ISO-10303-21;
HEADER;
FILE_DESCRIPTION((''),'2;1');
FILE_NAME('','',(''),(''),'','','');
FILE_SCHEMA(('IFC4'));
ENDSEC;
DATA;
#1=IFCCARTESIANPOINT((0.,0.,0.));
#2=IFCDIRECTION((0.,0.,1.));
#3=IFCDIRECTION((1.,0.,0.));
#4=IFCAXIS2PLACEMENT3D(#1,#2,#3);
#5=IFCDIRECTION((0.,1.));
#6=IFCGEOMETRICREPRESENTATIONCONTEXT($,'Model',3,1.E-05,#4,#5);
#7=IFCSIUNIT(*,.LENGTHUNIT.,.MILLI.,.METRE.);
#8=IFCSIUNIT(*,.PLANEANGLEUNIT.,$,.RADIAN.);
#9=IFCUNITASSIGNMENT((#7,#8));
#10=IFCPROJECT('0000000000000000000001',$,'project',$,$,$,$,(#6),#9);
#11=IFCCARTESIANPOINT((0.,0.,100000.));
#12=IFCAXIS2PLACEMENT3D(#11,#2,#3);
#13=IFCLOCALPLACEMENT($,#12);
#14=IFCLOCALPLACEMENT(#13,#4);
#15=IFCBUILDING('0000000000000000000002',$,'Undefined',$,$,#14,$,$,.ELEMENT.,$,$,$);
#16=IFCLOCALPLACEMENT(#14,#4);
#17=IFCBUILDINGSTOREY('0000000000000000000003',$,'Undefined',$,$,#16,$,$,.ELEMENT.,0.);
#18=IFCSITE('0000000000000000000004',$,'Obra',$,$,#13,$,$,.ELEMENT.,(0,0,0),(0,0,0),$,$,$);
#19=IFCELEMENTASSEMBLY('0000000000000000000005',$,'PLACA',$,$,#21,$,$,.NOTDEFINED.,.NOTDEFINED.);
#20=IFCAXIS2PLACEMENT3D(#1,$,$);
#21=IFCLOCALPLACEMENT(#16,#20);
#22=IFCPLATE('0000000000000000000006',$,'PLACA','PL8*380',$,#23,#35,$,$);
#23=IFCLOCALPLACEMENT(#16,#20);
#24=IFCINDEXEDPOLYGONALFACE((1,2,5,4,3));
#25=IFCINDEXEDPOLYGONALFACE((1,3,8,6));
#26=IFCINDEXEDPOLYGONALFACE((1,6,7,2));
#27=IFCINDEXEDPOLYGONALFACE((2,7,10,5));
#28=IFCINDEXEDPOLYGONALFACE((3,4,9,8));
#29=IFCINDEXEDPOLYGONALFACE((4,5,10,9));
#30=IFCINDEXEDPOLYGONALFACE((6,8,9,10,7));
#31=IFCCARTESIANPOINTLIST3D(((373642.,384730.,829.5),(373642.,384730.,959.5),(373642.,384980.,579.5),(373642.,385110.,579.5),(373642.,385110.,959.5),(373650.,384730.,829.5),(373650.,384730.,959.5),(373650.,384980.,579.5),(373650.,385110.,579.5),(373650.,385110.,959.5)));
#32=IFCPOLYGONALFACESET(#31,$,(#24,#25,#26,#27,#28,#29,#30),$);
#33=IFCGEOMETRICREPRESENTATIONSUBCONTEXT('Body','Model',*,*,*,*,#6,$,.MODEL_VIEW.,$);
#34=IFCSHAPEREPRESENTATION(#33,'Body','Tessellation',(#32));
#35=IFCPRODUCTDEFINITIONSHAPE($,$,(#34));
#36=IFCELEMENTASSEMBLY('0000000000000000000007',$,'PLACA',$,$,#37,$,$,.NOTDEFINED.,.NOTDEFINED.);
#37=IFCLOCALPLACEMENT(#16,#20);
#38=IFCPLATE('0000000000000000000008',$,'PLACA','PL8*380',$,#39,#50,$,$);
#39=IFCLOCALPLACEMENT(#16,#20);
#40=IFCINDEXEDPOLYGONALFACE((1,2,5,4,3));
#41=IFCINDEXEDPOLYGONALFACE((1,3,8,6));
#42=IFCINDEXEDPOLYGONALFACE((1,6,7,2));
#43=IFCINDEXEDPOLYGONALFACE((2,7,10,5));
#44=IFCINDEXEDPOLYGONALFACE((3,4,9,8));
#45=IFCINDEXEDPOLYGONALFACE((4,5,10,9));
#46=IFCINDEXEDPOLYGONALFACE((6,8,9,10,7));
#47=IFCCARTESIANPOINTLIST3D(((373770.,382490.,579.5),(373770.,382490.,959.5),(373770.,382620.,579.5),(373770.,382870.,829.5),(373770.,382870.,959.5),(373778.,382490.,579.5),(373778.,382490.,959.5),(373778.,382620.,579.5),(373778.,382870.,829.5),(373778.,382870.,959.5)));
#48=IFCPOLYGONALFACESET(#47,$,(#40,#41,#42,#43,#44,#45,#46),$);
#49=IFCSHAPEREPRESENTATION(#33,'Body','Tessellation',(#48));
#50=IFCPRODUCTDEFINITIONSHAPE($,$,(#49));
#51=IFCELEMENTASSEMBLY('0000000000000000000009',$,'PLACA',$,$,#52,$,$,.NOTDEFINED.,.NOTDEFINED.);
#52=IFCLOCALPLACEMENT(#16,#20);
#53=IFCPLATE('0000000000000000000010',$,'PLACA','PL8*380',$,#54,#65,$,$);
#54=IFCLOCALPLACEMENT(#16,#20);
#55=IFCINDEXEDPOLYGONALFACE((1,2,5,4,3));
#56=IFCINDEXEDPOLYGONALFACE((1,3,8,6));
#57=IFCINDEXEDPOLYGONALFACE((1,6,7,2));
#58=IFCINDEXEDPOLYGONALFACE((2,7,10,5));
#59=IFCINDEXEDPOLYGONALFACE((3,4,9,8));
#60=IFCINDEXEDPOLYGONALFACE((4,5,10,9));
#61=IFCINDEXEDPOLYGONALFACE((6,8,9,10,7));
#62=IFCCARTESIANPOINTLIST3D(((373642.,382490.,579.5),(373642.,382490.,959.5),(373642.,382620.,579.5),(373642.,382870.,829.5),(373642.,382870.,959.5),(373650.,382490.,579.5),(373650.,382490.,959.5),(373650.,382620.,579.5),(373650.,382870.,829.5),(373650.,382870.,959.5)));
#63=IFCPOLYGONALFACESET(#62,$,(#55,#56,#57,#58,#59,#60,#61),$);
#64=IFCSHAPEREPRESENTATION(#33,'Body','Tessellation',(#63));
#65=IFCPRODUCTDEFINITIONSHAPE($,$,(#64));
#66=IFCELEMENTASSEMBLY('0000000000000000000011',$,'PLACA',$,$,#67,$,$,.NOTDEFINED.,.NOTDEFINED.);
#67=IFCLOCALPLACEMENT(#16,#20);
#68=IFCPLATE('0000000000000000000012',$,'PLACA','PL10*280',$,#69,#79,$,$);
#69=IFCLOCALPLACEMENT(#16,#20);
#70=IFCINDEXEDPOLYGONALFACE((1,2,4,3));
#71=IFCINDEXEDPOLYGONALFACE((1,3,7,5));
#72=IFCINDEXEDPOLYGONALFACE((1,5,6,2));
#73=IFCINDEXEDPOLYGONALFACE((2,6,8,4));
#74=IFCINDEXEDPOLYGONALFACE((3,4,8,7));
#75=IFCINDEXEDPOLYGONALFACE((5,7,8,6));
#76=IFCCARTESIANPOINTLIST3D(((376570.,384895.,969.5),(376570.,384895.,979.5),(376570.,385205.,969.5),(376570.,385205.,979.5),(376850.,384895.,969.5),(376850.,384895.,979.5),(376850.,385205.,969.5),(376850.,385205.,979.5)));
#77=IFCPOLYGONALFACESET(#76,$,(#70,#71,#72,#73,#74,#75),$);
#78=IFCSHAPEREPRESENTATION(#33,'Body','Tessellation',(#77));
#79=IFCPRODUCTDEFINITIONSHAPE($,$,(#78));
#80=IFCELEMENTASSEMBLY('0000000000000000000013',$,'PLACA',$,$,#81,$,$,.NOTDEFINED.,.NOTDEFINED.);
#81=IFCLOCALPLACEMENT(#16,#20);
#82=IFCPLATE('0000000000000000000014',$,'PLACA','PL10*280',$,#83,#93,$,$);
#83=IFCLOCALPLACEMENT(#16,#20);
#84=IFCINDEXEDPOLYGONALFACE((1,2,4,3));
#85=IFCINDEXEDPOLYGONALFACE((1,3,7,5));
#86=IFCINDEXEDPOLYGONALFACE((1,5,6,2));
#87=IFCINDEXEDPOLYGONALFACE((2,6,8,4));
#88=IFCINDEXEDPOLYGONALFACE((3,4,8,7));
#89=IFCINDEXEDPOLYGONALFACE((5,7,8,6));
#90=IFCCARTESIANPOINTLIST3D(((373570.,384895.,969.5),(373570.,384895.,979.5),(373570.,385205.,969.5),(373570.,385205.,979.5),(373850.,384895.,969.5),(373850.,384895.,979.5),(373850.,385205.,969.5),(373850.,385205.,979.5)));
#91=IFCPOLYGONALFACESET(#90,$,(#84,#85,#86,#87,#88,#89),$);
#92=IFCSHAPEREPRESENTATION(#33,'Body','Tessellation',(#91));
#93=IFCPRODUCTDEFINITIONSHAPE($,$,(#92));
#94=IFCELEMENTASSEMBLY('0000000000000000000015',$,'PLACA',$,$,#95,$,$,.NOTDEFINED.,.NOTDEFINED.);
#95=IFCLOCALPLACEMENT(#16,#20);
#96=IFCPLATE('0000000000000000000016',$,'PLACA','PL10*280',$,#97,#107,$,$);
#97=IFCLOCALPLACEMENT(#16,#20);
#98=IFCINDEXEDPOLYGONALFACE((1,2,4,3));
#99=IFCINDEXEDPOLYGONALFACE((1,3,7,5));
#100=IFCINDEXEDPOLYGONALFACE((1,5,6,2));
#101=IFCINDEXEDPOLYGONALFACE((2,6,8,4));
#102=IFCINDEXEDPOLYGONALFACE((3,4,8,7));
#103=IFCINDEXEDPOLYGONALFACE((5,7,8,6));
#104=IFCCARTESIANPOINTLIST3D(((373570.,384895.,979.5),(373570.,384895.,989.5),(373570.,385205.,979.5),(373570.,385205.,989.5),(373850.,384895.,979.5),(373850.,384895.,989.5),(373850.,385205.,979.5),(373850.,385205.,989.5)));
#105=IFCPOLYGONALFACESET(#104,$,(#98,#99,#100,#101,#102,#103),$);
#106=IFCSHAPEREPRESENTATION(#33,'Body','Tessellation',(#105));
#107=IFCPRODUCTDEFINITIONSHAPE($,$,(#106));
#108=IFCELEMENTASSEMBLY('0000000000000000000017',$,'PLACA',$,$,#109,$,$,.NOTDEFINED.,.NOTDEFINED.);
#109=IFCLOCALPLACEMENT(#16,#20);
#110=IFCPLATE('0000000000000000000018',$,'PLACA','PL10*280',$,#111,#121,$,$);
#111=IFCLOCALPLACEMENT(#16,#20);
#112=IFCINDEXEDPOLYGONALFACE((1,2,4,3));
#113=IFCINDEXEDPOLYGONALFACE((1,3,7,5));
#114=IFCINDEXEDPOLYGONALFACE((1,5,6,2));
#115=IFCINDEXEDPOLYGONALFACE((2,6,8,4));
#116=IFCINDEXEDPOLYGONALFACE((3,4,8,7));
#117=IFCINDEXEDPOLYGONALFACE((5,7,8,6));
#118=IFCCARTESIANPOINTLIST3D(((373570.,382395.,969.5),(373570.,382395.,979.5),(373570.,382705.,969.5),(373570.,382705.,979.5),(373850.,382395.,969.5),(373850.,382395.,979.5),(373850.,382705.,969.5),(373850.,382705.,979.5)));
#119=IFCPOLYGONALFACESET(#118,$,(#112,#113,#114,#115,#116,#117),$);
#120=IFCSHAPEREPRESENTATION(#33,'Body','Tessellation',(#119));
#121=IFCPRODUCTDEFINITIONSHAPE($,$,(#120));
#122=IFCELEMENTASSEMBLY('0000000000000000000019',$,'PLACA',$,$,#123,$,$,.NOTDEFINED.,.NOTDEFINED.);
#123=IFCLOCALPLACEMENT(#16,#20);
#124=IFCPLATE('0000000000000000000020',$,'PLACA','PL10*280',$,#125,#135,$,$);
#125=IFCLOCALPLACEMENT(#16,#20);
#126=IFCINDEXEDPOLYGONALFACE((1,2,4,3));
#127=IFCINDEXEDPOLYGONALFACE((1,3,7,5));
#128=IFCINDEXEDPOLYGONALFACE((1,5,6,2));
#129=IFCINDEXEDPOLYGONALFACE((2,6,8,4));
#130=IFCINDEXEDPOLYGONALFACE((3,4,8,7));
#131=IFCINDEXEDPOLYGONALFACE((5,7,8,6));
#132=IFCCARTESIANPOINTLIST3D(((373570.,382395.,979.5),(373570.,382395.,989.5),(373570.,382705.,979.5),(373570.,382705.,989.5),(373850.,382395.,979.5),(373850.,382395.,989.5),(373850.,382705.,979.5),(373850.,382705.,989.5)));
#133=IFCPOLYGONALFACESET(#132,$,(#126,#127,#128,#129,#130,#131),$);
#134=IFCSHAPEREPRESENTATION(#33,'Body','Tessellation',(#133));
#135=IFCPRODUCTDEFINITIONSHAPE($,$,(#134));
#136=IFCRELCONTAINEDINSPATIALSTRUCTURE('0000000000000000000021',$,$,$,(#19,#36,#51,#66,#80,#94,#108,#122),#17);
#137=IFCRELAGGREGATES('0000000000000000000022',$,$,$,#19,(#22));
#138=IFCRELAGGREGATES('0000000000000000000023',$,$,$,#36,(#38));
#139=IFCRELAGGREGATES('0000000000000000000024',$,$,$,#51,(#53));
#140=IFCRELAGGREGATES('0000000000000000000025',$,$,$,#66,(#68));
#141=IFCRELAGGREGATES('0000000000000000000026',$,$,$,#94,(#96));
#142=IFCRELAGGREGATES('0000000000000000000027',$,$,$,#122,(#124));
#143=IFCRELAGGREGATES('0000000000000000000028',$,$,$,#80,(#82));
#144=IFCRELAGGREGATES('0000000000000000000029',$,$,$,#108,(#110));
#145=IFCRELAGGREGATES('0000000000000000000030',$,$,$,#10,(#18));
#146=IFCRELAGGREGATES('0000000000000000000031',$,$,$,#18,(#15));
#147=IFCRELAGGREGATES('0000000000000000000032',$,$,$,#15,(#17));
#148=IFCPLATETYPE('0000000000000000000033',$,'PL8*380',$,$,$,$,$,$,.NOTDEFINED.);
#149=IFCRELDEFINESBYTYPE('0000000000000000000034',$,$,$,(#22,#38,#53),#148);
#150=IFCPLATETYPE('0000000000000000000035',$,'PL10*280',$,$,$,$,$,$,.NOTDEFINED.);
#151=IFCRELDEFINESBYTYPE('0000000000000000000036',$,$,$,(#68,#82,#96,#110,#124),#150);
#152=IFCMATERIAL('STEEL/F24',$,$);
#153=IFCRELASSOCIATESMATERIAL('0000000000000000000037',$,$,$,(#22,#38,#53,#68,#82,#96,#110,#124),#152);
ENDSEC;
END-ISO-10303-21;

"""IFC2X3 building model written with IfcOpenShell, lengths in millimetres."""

from ifc_helpers import new_model, si_unit, direction, frame, origin_with_axes, place, context, subcontext, project, spatial, polyline, outline, extrude, material, type_object, element, aggregate, save


model = new_model("IFC2X3")

# Units and contexts
model_context = context("Model", 3, precision=1e-05, world=origin_with_axes(), true_north=direction((0.0, 1.0)))
body_context = subcontext(model_context, "Body", "Model", "MODEL_VIEW")
ifc_project = project(units=[si_unit("LENGTHUNIT", "METRE", prefix="MILLI"), si_unit("PLANEANGLEUNIT", "RADIAN")], contexts=[model_context])

# Site, building, storey
site_placement = place(None, frame((0.0, 0.0, 100000.0), z_axis=(0.0, 0.0, 1.0), x_axis=(1.0, 0.0, 0.0)))
site = spatial("IfcSite", under=ifc_project, at=site_placement, Name="Obra", CompositionType="ELEMENT", RefLatitude=(0, 0, 0), RefLongitude=(0, 0, 0))
building_placement = place(site_placement, origin_with_axes())
building = spatial("IfcBuilding", under=site, at=building_placement, Name="Undefined", CompositionType="ELEMENT")
storey_placement = place(building_placement, origin_with_axes())
storey = spatial("IfcBuildingStorey", under=building, at=storey_placement, Name="Undefined", CompositionType="ELEMENT", Elevation=0.0)

# Shared definitions
ifc_material_1 = material(Name="STEEL/F24")

# Element assemblies, plates
plate_type_1 = type_object("IfcPlateType", Name="PL8*380", PredefinedType="NOTDEFINED")
assembly_1_placement = place(storey_placement, origin_with_axes())
assembly_1 = element("IfcElementAssembly", 1, at=assembly_1_placement, inside=storey, Name="PLACA", AssemblyPlace="NOTDEFINED", PredefinedType="NOTDEFINED")
plate_1_placement = place(assembly_1_placement, frame((373646.0, 384730.0, 959.5), z_axis=(-1.0, 0.0, 0.0), x_axis=(0.0, 1.0, 0.0)))
plate_1 = element("IfcPlate", 2, at=plate_1_placement, type_object=plate_type_1, material=ifc_material_1, Name="PLACA", Description="PL8*380", context=body_context, shape_type="SweptSolid", body=[
    extrude(outline(polyline([(0.0, 0.0), (380.0, 0.0), (380.0, 380.0), (250.0, 380.0), (0.0, 130.0), (0.0, 0.0)])), frame((0.0, 0.0, -4.0), z_axis=(0.0, 0.0, 1.0), x_axis=(1.0, 0.0, 0.0)), (0.0, 0.0, 1.0), 8.0),
])
aggregate(assembly_1, [plate_1])
assembly_2_placement = place(storey_placement, origin_with_axes())
assembly_2 = element("IfcElementAssembly", 3, at=assembly_2_placement, inside=storey, Name="PLACA", AssemblyPlace="NOTDEFINED", PredefinedType="NOTDEFINED")
plate_2_placement = place(assembly_2_placement, frame((373774.0, 382870.0, 959.5), z_axis=(1.0, 0.0, 0.0), x_axis=(0.0, -1.0, 0.0)))
plate_2 = element("IfcPlate", 4, at=plate_2_placement, type_object=plate_type_1, material=ifc_material_1, Name="PLACA", Description="PL8*380", context=body_context, shape_type="SweptSolid", body=[
    extrude(outline(polyline([(0.0, 0.0), (380.0, 0.0), (380.0, 380.0), (250.0, 380.0), (0.0, 130.0), (0.0, 0.0)])), frame((0.0, 0.0, -4.0), z_axis=(0.0, 0.0, 1.0), x_axis=(1.0, 0.0, 0.0)), (0.0, 0.0, 1.0), 8.0),
])
aggregate(assembly_2, [plate_2])
assembly_3_placement = place(storey_placement, origin_with_axes())
assembly_3 = element("IfcElementAssembly", 5, at=assembly_3_placement, inside=storey, Name="PLACA", AssemblyPlace="NOTDEFINED", PredefinedType="NOTDEFINED")
plate_3_placement = place(assembly_3_placement, frame((373646.0, 382870.0, 959.5), z_axis=(1.0, 0.0, 0.0), x_axis=(0.0, -1.0, 0.0)))
plate_3 = element("IfcPlate", 6, at=plate_3_placement, type_object=plate_type_1, material=ifc_material_1, Name="PLACA", Description="PL8*380", context=body_context, shape_type="SweptSolid", body=[
    extrude(outline(polyline([(0.0, 0.0), (380.0, 0.0), (380.0, 380.0), (250.0, 380.0), (0.0, 130.0), (0.0, 0.0)])), frame((0.0, 0.0, -4.0), z_axis=(0.0, 0.0, 1.0), x_axis=(1.0, 0.0, 0.0)), (0.0, 0.0, 1.0), 8.0),
])
aggregate(assembly_3, [plate_3])
assembly_4_placement = place(storey_placement, origin_with_axes())
assembly_4 = element("IfcElementAssembly", 7, at=assembly_4_placement, inside=storey, Name="PLACA", AssemblyPlace="NOTDEFINED", PredefinedType="NOTDEFINED")
plate_type_2 = type_object("IfcPlateType", Name="PL10*280", PredefinedType="NOTDEFINED")
plate_4_placement = place(assembly_4_placement, frame((376570.0, 385205.0, 974.5), z_axis=(0.0, 0.0, -1.0), x_axis=(1.0, 0.0, 0.0)))
plate_4 = element("IfcPlate", 8, at=plate_4_placement, type_object=plate_type_2, material=ifc_material_1, Name="PLACA", Description="PL10*280", context=body_context, shape_type="SweptSolid", body=[
    extrude(outline(polyline([(0.0, 0.0), (280.0, 0.0), (280.0, 310.0), (0.0, 310.0), (0.0, 0.0)])), frame((0.0, 0.0, -5.0), z_axis=(0.0, 0.0, 1.0), x_axis=(1.0, 0.0, 0.0)), (0.0, 0.0, 1.0), 10.0),
])
aggregate(assembly_4, [plate_4])
assembly_5_placement = place(storey_placement, origin_with_axes())
assembly_5 = element("IfcElementAssembly", 9, at=assembly_5_placement, inside=storey, Name="PLACA", AssemblyPlace="NOTDEFINED", PredefinedType="NOTDEFINED")
plate_5_placement = place(assembly_5_placement, frame((373570.0, 385205.0, 974.5), z_axis=(0.0, 0.0, -1.0), x_axis=(1.0, 0.0, 0.0)))
plate_5 = element("IfcPlate", 10, at=plate_5_placement, type_object=plate_type_2, material=ifc_material_1, Name="PLACA", Description="PL10*280", context=body_context, shape_type="SweptSolid", body=[
    extrude(outline(polyline([(0.0, 0.0), (280.0, 0.0), (280.0, 310.0), (0.0, 310.0), (0.0, 0.0)])), frame((0.0, 0.0, -5.0), z_axis=(0.0, 0.0, 1.0), x_axis=(1.0, 0.0, 0.0)), (0.0, 0.0, 1.0), 10.0),
])
assembly_6_placement = place(storey_placement, origin_with_axes())
assembly_6 = element("IfcElementAssembly", 11, at=assembly_6_placement, inside=storey, Name="PLACA", AssemblyPlace="NOTDEFINED", PredefinedType="NOTDEFINED")
plate_6_placement = place(assembly_6_placement, frame((373570.0, 385205.0, 984.5), z_axis=(0.0, 0.0, -1.0), x_axis=(1.0, 0.0, 0.0)))
plate_6 = element("IfcPlate", 12, at=plate_6_placement, type_object=plate_type_2, material=ifc_material_1, Name="PLACA", Description="PL10*280", context=body_context, shape_type="SweptSolid", body=[
    extrude(outline(polyline([(0.0, 0.0), (280.0, 0.0), (280.0, 310.0), (0.0, 310.0), (0.0, 0.0)])), frame((0.0, 0.0, -5.0), z_axis=(0.0, 0.0, 1.0), x_axis=(1.0, 0.0, 0.0)), (0.0, 0.0, 1.0), 10.0),
])
aggregate(assembly_6, [plate_6])
assembly_7_placement = place(storey_placement, origin_with_axes())
assembly_7 = element("IfcElementAssembly", 13, at=assembly_7_placement, inside=storey, Name="PLACA", AssemblyPlace="NOTDEFINED", PredefinedType="NOTDEFINED")
plate_7_placement = place(assembly_7_placement, frame((373570.0, 382395.0, 974.5), z_axis=(0.0, 0.0, 1.0), x_axis=(1.0, 0.0, 0.0)))
plate_7 = element("IfcPlate", 14, at=plate_7_placement, type_object=plate_type_2, material=ifc_material_1, Name="PLACA", Description="PL10*280", context=body_context, shape_type="SweptSolid", body=[
    extrude(outline(polyline([(0.0, 0.0), (280.0, 0.0), (280.0, 310.0), (0.0, 310.0), (0.0, 0.0)])), frame((0.0, 0.0, -5.0), z_axis=(0.0, 0.0, 1.0), x_axis=(1.0, 0.0, 0.0)), (0.0, 0.0, 1.0), 10.0),
])
assembly_8_placement = place(storey_placement, origin_with_axes())
assembly_8 = element("IfcElementAssembly", 15, at=assembly_8_placement, inside=storey, Name="PLACA", AssemblyPlace="NOTDEFINED", PredefinedType="NOTDEFINED")
plate_8_placement = place(assembly_8_placement, frame((373570.0, 382395.0, 984.5), z_axis=(0.0, 0.0, 1.0), x_axis=(1.0, 0.0, 0.0)))
plate_8 = element("IfcPlate", 16, at=plate_8_placement, type_object=plate_type_2, material=ifc_material_1, Name="PLACA", Description="PL10*280", context=body_context, shape_type="SweptSolid", body=[
    extrude(outline(polyline([(0.0, 0.0), (280.0, 0.0), (280.0, 310.0), (0.0, 310.0), (0.0, 0.0)])), frame((0.0, 0.0, -5.0), z_axis=(0.0, 0.0, 1.0), x_axis=(1.0, 0.0, 0.0)), (0.0, 0.0, 1.0), 10.0),
])
aggregate(assembly_8, [plate_8])

aggregate(assembly_5, [plate_5])
aggregate(assembly_7, [plate_7])

save(model, "model.ifc")
